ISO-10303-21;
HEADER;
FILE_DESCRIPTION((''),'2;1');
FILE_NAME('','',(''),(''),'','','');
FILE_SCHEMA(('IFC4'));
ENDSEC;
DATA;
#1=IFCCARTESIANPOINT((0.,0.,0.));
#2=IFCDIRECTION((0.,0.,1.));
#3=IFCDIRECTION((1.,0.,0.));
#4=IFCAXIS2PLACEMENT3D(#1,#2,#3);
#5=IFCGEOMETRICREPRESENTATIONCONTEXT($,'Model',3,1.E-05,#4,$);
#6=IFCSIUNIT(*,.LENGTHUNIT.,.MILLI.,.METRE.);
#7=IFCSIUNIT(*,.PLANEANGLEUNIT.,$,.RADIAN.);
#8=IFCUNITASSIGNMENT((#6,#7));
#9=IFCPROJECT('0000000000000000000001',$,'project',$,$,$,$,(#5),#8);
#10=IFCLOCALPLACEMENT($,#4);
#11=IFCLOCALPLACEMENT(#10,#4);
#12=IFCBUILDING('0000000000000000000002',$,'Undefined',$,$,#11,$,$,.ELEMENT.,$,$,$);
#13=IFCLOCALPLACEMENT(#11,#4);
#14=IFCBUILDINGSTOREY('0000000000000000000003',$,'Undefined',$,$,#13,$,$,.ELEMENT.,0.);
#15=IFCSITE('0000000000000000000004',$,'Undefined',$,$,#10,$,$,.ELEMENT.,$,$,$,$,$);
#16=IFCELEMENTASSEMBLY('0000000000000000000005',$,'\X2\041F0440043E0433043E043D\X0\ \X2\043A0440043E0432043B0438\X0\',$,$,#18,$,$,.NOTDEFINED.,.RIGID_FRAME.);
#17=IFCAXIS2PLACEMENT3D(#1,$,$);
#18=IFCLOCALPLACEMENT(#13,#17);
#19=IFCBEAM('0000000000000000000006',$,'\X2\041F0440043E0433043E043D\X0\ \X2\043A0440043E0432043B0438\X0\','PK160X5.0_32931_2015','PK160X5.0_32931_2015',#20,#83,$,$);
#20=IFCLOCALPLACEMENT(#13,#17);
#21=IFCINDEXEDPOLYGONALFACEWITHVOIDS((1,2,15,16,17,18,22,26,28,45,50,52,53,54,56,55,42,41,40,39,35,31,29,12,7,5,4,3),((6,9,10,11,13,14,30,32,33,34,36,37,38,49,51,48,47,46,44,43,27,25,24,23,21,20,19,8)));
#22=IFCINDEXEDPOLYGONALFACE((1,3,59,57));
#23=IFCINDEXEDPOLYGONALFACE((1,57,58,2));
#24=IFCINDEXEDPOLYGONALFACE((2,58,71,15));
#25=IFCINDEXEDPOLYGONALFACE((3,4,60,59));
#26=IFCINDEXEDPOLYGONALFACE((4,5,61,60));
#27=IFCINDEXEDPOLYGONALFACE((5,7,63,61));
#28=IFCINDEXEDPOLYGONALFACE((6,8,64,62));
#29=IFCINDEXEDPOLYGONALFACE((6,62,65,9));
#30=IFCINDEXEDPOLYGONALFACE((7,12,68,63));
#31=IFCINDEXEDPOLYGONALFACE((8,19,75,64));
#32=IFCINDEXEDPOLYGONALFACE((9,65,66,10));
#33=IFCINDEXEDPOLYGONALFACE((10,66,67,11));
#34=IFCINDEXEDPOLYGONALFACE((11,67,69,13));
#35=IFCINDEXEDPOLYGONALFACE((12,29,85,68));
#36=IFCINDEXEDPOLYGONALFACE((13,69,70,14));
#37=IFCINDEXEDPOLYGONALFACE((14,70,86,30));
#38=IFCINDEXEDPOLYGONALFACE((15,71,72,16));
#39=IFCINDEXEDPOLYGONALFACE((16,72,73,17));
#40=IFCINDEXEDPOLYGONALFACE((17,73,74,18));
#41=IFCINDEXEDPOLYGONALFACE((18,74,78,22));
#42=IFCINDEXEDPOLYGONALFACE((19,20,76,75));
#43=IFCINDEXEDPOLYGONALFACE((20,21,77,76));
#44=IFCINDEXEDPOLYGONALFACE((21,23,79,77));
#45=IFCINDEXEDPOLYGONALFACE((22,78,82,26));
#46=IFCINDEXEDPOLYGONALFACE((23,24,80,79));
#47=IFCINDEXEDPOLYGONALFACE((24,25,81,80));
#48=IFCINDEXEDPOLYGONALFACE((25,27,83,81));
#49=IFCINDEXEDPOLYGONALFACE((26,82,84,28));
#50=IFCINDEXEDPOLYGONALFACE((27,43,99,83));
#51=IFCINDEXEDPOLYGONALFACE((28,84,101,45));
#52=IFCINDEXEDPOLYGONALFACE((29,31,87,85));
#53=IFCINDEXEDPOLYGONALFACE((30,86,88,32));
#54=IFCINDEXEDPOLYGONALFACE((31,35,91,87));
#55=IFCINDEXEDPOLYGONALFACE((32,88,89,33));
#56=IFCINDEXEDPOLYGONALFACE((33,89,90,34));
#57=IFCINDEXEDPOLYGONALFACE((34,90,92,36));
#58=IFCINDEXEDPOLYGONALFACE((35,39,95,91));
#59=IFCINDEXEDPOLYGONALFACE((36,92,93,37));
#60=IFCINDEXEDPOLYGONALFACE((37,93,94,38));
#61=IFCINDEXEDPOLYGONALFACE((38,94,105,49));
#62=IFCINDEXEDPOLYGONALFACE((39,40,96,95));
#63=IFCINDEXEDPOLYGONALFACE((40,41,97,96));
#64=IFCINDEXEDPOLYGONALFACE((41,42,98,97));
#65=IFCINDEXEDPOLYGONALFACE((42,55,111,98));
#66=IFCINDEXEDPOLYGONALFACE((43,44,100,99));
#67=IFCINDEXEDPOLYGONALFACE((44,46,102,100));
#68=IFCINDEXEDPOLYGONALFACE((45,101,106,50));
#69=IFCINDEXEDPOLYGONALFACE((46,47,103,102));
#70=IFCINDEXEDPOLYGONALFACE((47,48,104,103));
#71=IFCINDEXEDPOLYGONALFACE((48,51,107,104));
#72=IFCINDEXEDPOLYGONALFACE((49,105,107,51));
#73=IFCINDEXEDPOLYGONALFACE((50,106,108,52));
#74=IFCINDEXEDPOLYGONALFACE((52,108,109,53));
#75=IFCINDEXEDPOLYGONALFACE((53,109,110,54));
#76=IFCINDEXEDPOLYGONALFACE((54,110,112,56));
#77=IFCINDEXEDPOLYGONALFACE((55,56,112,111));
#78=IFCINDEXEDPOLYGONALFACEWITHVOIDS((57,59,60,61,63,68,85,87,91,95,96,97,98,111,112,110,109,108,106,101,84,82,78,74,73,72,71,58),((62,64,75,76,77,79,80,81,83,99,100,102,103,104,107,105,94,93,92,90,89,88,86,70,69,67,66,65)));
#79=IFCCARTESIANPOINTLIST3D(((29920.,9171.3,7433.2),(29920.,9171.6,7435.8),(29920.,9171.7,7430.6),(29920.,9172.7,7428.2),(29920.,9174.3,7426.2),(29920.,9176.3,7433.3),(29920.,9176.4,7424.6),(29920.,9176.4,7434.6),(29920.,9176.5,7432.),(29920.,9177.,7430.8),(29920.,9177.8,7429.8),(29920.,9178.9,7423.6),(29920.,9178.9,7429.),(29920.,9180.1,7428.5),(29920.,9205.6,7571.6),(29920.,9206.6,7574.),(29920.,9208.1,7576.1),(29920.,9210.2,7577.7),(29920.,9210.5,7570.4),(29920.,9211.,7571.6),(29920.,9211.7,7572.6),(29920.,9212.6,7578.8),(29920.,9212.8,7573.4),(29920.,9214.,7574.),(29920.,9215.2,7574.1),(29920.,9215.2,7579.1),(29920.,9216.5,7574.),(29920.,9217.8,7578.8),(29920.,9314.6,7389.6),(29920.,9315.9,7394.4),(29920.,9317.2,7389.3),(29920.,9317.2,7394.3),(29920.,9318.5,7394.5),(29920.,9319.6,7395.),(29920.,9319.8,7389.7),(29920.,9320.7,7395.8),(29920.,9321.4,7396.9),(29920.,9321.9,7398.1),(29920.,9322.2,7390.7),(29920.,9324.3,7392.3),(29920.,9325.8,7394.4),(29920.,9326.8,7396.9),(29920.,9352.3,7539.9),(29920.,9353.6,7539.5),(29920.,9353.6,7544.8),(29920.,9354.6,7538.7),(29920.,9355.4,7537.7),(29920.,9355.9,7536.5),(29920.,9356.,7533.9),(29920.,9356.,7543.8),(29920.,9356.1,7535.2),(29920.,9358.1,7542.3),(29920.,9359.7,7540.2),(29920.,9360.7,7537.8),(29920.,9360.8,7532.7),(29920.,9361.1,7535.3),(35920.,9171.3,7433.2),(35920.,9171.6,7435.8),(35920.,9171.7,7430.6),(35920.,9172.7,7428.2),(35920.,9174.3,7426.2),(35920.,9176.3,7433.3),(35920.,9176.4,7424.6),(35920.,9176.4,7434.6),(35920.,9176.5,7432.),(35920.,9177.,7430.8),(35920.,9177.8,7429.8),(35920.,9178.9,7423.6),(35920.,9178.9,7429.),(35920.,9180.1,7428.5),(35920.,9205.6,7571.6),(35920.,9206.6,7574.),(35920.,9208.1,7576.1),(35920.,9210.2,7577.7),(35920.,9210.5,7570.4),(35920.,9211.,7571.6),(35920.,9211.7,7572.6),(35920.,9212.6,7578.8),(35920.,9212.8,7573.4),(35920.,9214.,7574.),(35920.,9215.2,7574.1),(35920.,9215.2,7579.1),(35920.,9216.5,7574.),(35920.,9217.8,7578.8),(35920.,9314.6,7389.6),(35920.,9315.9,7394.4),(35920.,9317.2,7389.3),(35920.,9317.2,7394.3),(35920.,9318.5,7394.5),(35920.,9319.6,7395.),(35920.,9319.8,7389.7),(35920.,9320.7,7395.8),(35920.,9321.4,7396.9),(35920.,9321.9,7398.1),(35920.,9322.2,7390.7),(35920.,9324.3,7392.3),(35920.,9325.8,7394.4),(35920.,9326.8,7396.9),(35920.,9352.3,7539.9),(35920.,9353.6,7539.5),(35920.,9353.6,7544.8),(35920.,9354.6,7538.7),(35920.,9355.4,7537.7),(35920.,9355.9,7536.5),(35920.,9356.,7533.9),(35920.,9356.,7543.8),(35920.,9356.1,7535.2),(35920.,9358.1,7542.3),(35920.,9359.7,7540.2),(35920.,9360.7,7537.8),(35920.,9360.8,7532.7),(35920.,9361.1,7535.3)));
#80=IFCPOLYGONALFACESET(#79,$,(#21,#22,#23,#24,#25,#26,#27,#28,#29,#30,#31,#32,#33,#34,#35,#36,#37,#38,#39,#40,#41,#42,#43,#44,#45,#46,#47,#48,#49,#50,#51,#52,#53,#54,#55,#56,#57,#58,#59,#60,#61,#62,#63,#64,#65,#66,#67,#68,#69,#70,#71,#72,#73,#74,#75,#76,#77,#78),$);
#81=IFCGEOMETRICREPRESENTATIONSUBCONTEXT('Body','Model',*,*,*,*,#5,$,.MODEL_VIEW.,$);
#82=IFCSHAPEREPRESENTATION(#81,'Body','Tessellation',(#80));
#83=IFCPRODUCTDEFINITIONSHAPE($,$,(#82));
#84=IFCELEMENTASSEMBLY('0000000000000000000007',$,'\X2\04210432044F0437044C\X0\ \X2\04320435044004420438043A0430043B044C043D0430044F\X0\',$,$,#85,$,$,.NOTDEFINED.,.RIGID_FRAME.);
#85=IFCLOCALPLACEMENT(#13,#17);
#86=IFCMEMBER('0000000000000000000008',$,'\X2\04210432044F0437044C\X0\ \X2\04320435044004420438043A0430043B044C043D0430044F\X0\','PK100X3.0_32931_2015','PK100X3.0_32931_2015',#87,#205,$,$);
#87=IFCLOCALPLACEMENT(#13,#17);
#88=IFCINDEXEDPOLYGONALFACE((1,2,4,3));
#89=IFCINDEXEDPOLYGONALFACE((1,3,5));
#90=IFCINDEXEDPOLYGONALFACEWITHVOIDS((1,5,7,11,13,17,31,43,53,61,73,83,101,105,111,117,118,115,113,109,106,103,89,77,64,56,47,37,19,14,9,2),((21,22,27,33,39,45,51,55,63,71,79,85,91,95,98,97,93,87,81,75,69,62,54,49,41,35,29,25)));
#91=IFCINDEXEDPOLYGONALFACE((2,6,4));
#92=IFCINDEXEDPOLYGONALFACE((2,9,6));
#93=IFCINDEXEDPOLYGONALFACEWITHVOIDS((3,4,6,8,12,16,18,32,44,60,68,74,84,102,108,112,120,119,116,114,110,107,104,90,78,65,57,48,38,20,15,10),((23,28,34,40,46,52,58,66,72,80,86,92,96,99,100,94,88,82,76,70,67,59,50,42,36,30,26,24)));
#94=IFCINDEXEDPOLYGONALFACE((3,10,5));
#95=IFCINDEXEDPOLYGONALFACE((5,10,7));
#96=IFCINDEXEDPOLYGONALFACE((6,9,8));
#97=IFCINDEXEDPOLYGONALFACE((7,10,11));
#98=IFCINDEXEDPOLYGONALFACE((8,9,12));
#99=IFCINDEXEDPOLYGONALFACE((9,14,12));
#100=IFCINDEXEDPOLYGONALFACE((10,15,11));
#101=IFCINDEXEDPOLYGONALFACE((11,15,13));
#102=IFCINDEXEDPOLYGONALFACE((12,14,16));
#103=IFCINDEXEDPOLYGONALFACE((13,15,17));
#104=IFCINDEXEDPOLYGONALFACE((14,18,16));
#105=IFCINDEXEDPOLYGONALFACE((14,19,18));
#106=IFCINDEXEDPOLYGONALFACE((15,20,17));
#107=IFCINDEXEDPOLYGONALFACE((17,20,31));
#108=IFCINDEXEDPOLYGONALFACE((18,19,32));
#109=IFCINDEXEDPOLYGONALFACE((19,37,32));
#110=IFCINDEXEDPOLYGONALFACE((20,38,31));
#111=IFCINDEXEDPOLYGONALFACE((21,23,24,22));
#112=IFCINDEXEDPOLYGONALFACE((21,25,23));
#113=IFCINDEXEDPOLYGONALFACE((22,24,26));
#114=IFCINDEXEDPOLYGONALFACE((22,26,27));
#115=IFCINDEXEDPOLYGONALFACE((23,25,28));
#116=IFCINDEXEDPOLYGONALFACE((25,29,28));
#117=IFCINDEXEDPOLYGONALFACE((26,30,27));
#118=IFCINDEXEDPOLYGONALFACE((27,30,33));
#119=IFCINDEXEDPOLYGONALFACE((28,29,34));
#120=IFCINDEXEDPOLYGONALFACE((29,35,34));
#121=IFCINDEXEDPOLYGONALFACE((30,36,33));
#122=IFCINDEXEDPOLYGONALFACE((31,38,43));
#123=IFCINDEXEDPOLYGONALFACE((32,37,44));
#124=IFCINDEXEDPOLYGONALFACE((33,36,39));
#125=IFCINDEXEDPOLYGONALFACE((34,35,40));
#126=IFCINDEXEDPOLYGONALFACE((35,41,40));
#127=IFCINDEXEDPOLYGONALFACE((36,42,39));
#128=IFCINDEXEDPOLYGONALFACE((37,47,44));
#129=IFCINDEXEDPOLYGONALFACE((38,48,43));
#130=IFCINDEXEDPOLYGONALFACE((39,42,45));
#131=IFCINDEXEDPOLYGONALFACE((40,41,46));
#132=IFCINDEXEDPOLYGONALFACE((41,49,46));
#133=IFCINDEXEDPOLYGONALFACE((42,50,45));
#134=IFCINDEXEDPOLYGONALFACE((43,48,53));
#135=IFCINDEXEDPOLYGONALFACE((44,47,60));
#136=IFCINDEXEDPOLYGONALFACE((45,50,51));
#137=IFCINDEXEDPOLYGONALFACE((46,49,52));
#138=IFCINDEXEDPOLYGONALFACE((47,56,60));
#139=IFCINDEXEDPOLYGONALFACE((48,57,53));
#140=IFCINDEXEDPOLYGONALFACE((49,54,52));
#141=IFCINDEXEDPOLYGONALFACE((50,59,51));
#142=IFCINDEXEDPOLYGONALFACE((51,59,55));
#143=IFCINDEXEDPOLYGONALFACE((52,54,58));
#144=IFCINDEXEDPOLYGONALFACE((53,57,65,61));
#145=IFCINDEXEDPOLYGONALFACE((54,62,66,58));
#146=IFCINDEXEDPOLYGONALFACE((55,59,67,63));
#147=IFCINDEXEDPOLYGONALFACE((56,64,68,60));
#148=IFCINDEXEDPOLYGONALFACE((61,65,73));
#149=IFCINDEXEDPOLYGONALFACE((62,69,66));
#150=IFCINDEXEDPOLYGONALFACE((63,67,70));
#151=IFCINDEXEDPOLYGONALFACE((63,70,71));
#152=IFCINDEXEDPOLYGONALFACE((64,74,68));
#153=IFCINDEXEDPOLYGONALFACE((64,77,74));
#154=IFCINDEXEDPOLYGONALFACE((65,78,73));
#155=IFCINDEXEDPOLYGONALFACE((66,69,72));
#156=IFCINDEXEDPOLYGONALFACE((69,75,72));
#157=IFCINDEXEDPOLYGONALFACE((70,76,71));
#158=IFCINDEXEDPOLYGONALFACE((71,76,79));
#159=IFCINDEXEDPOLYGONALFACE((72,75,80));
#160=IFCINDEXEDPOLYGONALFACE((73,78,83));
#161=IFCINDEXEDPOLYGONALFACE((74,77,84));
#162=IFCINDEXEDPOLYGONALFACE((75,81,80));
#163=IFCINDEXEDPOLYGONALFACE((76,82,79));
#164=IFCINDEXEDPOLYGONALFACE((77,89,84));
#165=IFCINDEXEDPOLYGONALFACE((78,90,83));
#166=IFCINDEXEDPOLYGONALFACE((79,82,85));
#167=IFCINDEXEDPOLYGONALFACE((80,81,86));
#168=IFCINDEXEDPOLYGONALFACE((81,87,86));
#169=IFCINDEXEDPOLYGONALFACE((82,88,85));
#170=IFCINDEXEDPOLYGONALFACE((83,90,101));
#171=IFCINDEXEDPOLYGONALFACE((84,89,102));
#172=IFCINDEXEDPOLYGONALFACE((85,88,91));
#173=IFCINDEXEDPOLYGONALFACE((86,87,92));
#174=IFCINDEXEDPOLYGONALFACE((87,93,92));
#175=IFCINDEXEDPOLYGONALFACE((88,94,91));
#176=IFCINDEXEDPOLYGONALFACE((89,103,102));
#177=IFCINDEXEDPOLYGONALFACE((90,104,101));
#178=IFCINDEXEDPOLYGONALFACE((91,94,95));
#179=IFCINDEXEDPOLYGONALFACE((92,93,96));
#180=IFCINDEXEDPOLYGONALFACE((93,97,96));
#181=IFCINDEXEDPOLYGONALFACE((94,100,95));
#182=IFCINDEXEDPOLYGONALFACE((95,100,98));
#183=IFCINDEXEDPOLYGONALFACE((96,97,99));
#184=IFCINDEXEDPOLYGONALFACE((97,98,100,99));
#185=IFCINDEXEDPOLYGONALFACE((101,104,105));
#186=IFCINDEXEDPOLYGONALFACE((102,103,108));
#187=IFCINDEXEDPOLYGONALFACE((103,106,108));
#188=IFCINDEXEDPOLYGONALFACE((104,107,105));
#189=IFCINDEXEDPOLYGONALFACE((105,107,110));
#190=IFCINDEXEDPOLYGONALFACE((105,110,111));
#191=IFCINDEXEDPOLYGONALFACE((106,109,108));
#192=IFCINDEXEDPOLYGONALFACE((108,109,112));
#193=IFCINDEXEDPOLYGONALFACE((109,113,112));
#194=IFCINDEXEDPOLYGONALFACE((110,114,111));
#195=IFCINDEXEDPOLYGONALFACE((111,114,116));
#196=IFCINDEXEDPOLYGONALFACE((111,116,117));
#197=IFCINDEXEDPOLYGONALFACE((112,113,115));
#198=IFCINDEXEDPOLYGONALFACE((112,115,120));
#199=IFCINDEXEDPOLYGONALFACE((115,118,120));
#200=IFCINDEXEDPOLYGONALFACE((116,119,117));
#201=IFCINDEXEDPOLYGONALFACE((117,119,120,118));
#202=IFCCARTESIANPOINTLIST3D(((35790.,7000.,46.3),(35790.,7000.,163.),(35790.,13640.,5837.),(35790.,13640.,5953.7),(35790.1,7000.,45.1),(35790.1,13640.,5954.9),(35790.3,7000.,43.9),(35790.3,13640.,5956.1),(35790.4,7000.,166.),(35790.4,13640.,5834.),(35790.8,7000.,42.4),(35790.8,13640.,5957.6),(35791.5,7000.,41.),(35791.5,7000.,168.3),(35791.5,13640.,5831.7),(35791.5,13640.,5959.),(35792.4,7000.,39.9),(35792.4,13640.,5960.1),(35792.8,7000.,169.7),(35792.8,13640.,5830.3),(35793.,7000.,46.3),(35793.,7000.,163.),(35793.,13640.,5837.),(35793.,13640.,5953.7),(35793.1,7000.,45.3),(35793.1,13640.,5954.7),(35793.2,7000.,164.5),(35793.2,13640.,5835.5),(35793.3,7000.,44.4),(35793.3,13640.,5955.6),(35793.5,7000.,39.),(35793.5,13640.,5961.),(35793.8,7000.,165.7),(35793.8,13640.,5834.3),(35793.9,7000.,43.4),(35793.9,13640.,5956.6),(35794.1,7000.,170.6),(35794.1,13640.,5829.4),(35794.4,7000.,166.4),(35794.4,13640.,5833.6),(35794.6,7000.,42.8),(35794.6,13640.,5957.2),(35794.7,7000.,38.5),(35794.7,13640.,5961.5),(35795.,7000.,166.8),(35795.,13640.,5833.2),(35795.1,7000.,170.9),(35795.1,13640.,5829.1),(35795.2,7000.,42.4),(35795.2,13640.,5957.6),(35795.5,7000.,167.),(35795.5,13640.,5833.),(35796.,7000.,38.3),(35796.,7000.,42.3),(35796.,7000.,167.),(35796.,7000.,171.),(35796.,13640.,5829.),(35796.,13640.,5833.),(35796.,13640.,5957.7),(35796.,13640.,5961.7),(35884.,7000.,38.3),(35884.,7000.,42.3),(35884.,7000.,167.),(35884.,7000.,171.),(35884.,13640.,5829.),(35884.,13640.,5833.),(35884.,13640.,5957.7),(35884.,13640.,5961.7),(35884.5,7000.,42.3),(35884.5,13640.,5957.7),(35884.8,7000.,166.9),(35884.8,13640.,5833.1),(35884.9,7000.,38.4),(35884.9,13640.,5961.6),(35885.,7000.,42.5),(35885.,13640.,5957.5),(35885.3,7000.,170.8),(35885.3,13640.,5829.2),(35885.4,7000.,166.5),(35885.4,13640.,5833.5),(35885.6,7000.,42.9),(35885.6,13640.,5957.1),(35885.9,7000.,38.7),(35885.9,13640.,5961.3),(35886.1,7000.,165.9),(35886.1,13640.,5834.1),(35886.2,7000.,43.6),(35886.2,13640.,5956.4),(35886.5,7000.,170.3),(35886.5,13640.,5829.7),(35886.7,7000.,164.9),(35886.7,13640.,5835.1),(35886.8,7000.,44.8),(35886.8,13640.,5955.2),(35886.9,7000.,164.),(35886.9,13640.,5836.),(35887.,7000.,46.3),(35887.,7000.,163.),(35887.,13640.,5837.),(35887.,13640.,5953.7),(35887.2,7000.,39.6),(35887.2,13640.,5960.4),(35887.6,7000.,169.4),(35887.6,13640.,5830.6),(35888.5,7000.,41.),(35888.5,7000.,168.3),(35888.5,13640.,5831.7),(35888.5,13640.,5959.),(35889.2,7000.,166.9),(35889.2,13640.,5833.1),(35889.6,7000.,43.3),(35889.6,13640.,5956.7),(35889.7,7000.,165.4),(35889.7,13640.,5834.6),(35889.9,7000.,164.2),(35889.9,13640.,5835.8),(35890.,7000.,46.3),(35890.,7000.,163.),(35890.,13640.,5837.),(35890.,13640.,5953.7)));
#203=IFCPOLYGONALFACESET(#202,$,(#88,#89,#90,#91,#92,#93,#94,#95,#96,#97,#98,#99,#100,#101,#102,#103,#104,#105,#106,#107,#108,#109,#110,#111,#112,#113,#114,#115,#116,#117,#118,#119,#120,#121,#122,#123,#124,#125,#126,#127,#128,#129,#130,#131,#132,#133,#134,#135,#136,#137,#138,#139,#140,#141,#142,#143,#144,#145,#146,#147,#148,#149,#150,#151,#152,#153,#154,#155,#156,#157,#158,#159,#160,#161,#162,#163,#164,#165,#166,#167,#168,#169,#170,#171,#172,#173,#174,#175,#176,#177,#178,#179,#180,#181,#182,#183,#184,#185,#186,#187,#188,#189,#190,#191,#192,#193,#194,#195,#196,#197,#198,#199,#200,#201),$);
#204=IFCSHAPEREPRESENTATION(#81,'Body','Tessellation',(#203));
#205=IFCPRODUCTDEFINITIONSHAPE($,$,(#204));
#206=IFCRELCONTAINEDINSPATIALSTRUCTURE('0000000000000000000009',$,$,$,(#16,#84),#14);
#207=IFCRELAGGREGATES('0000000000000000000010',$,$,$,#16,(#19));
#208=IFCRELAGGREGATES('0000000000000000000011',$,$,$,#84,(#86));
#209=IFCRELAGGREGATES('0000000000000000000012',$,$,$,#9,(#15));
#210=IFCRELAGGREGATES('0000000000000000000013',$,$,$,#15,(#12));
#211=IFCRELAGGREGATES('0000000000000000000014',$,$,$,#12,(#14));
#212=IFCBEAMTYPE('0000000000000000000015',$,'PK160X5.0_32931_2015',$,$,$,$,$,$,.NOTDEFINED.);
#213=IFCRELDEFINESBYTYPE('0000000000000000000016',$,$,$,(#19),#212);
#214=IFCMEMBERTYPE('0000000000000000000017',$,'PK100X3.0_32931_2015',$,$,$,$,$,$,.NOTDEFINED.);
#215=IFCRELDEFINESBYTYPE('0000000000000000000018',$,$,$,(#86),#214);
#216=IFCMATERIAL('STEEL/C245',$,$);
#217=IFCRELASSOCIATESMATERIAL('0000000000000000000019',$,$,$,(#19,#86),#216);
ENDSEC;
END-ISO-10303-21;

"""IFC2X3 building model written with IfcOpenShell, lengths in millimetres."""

from ifc_helpers import new_model, si_unit, frame, origin_with_axes, origin_2d_with_axis, place, context, subcontext, project, spatial, hollow_rectangle, extrude, clip, halfspace, material, type_object, element, aggregate, save


model = new_model("IFC2X3")

# Units and contexts
model_context = context("Model", 3, precision=1e-05, world=origin_with_axes())
body_context = subcontext(model_context, "Body", "Model", "MODEL_VIEW")
ifc_project = project(units=[si_unit("LENGTHUNIT", "METRE", prefix="MILLI"), si_unit("PLANEANGLEUNIT", "RADIAN")], contexts=[model_context])

# Site, building, storey
site_placement = place(None, origin_with_axes())
site = spatial("IfcSite", under=ifc_project, at=site_placement, Name="Undefined", CompositionType="ELEMENT")
building_placement = place(site_placement, origin_with_axes())
building = spatial("IfcBuilding", under=site, at=building_placement, Name="Undefined", CompositionType="ELEMENT")
storey_placement = place(building_placement, origin_with_axes())
storey = spatial("IfcBuildingStorey", under=building, at=storey_placement, Name="Undefined", CompositionType="ELEMENT", Elevation=0.0)

# Shared definitions
ifc_material = material(Name="STEEL/C245")

# Element assembly, beam
beam_type_1 = type_object("IfcBeamType", Name="PK160X5.0_32931_2015", PredefinedType="NOTDEFINED")
assembly_1_placement = place(storey_placement, origin_with_axes())
assembly_1 = element("IfcElementAssembly", 1, at=assembly_1_placement, inside=storey, Name="Прогон кровли", AssemblyPlace="NOTDEFINED", PredefinedType="RIGID_FRAME")
beam_1_placement = place(assembly_1_placement, frame((29920.0, 9266.2, 7484.2), z_axis=(0.0, 0.243188, 0.969979), x_axis=(1.0, 0.0, 0.0)))
beam_1 = element("IfcBeam", 2, at=beam_1_placement, type_object=beam_type_1, material=ifc_material, Name="Прогон кровли", Description="PK160X5.0_32931_2015", ObjectType="PK160X5.0_32931_2015", context=body_context, shape_type="SweptSolid", body=[
    extrude(hollow_rectangle(XDim=160.0, YDim=160.0, WallThickness=5.0, InnerFilletRadius=5.0, OuterFilletRadius=10.0, at=origin_2d_with_axis()), frame((6000.0, 0.0, 0.0), z_axis=(-1.0, 0.0, 0.0), x_axis=(0.0, -1.0, 0.0)), (0.0, 0.0, 1.0), 6000.0),
])
aggregate(assembly_1, [beam_1])

# Element assembly, member
member_type_1 = type_object("IfcMemberType", Name="PK100X3.0_32931_2015", PredefinedType="NOTDEFINED")
assembly_2_placement = place(storey_placement, origin_with_axes())
assembly_2 = element("IfcElementAssembly", 3, at=assembly_2_placement, inside=storey, Name="Связь вертикальная", AssemblyPlace="NOTDEFINED", PredefinedType="RIGID_FRAME")
member_1_placement = place(assembly_2_placement, frame((35840.0, 6880.0, 0.0), z_axis=(0.0, -0.657263, 0.753661), x_axis=(0.0, 0.753661, 0.657263)))
member_1 = element("IfcMember", 4, at=member_1_placement, type_object=member_type_1, material=ifc_material, Name="Связь вертикальная", Description="PK100X3.0_32931_2015", ObjectType="PK100X3.0_32931_2015", context=body_context, shape_type="Clipping", body=[
    clip(clip(extrude(hollow_rectangle(XDim=100.0, YDim=100.0, WallThickness=3.0, InnerFilletRadius=3.0, OuterFilletRadius=6.0, at=origin_2d_with_axis()), frame((9057.6, 0.0, 0.0), z_axis=(-1.0, 0.0, 0.0), x_axis=(0.0, -1.0, 0.0)), (0.0, 0.0, 1.0), 8986.5), halfspace(frame((8885.2, 0.0, -96.7), z_axis=(-0.753661, 0.0, 0.657263), x_axis=(-0.657263, 0.0, -0.753661)), True)), halfspace(frame((281.8, 0.0, 140.5), z_axis=(0.753661, 0.0, -0.657263), x_axis=(0.657263, 0.0, 0.753661)), True)),
])
aggregate(assembly_2, [member_1])

save(model, "model.ifc")
